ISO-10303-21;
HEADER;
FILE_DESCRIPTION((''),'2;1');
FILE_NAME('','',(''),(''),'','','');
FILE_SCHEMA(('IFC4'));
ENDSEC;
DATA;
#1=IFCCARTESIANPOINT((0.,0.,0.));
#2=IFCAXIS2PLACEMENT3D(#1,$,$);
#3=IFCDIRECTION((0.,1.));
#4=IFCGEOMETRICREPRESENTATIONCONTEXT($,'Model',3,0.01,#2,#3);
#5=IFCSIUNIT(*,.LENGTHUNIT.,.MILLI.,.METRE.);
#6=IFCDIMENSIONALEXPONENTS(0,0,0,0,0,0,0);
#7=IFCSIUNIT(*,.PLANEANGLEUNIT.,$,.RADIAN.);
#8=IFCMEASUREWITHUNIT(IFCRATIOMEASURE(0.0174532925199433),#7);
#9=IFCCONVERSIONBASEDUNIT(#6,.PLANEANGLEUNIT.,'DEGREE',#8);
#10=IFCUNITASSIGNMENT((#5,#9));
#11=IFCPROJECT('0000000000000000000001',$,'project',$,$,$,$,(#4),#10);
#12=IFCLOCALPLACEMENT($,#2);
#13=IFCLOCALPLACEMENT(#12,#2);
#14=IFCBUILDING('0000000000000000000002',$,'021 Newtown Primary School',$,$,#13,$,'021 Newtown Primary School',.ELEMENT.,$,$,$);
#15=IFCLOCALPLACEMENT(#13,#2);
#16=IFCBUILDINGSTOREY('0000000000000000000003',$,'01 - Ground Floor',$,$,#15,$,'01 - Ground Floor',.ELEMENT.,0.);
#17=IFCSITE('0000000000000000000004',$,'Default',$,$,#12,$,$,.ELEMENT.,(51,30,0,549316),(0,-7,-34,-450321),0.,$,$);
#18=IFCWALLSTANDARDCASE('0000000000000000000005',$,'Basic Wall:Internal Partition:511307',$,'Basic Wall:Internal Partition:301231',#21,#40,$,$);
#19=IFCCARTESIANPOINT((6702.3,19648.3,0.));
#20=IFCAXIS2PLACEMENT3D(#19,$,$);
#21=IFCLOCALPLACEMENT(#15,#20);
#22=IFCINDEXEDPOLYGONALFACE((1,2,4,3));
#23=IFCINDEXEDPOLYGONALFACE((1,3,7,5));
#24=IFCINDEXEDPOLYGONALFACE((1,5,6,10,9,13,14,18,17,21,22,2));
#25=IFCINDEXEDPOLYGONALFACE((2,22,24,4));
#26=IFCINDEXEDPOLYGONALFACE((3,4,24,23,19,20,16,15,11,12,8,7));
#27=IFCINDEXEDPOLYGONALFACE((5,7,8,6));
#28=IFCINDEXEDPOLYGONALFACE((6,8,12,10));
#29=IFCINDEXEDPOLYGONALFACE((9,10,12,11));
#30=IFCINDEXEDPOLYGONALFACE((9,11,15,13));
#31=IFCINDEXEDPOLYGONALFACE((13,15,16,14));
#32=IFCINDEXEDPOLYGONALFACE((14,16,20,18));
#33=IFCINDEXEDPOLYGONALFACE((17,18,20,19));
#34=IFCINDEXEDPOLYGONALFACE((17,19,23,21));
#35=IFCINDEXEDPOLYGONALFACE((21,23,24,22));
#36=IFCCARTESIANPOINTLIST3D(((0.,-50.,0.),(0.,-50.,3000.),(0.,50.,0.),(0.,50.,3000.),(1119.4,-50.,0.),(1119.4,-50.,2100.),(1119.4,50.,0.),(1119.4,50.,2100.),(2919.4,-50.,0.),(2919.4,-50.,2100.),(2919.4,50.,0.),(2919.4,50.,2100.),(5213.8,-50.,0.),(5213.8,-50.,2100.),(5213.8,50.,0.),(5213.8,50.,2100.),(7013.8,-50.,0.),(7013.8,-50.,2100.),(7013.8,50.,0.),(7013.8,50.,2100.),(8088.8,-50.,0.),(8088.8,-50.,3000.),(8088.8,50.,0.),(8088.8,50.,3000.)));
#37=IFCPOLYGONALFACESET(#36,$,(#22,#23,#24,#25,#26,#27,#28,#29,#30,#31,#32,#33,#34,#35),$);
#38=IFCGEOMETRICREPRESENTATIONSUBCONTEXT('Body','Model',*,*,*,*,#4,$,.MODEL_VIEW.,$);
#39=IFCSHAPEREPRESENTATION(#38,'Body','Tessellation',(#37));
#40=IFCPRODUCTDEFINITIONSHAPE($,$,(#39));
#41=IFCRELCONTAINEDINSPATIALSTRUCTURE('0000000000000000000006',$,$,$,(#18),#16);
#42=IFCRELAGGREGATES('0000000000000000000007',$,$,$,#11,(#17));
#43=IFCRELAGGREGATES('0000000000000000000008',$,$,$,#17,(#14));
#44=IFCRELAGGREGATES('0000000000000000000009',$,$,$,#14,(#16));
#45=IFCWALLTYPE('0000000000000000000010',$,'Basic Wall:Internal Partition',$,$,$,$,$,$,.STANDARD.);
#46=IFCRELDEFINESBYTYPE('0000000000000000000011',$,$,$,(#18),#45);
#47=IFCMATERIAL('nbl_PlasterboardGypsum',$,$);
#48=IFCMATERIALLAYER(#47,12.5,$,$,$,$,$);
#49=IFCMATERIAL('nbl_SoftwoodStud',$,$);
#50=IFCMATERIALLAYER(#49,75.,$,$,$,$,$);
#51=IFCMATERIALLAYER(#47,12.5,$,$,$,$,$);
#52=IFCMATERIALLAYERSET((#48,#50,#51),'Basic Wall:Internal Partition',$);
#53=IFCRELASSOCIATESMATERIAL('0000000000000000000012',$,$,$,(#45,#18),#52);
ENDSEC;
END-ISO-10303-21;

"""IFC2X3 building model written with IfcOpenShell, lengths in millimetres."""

from ifc_helpers import new_model, entity, si_unit, converted_unit, direction, frame, frame_2d, origin, place, context, subcontext, project, spatial, rectangle, extrude, material, layer, layer_set, layer_usage, type_object, element, save


model = new_model("IFC2X3")

# Units and contexts
model_context = context("Model", 3, precision=0.01, world=origin(), true_north=direction((0.0, 1.0)))
body_context = subcontext(model_context, "Body", "Model", "MODEL_VIEW")
ifc_project = project(units=[si_unit("LENGTHUNIT", "METRE", prefix="MILLI"), converted_unit("PLANEANGLEUNIT", "DEGREE", entity("IfcRatioMeasure", 0.0174532925199433), si_unit("PLANEANGLEUNIT", "RADIAN"), dimensions=[0, 0, 0, 0, 0, 0, 0])], contexts=[model_context])

# Site, building, storey
site_placement = place(None, origin())
site = spatial("IfcSite", under=ifc_project, at=site_placement, Name="Default", CompositionType="ELEMENT", RefLatitude=(51, 30, 0, 549316), RefLongitude=(0, -7, -34, -450321), RefElevation=0.0)
building_placement = place(site_placement, origin())
building = spatial("IfcBuilding", under=site, at=building_placement, Name="021 Newtown Primary School", LongName="021 Newtown Primary School", CompositionType="ELEMENT")
storey_placement = place(building_placement, origin())
storey = spatial("IfcBuildingStorey", under=building, at=storey_placement, Name="01 - Ground Floor", LongName="01 - Ground Floor", CompositionType="ELEMENT", Elevation=0.0)

# Shared definitions
ifc_material_1 = material(Name="nbl_PlasterboardGypsum")
ifc_layer_1 = layer(ifc_material_1, 12.5)
ifc_material_2 = material(Name="nbl_SoftwoodStud")
ifc_layer_2 = layer(ifc_material_2, 75.0)
ifc_layer_3 = layer(ifc_material_1, 12.5)
ifc_layer_set_1 = layer_set([ifc_layer_1, ifc_layer_2, ifc_layer_3], Name="Basic Wall:Internal Partition")
wall_type_1 = type_object("IfcWallType", Name="Basic Wall:Internal Partition", PredefinedType="STANDARD", material=ifc_layer_set_1)

# Wall, openings
ifc_layer_usage_1 = layer_usage(ifc_layer_set_1, "AXIS2", "NEGATIVE", 50.0)
wall_1_placement = place(storey_placement, frame((6702.3, 19648.3, 0.0)))
wall_1 = element("IfcWallStandardCase", 1, at=wall_1_placement, inside=storey, type_object=wall_type_1, material=ifc_layer_usage_1, Name="Basic Wall:Internal Partition:511307", ObjectType="Basic Wall:Internal Partition:301231", context=body_context, shape_type="SweptSolid", body=[
    extrude(rectangle(XDim=8088.8, YDim=100.0, at=frame_2d((4044.4, 0.0), x_axis=(-1.0, 0.0))), origin(), (0.0, 0.0, 1.0), 3000.0),
])
opening_1_placement = place(wall_1_placement, origin())
element("IfcOpeningElement", 2, at=opening_1_placement, cuts=wall_1, ObjectType="Opening", context=body_context, shape_type="SweptSolid", body=[
    extrude(rectangle(XDim=2100.0, YDim=1800.0, at=frame_2d((0.0, 0.0), x_axis=(1.0, 0.0))), frame((2019.4, -1474.0, 1050.0), z_axis=(0.0, 1.0, 0.0), x_axis=(0.0, 0.0, 1.0)), (0.0, 0.0, 1.0), 3048.0),
])
opening_2_placement = place(wall_1_placement, origin())
element("IfcOpeningElement", 3, at=opening_2_placement, cuts=wall_1, ObjectType="Opening", context=body_context, shape_type="SweptSolid", body=[
    extrude(rectangle(XDim=2100.0, YDim=1800.0, at=frame_2d((0.0, 0.0), x_axis=(1.0, 0.0))), frame((6113.8, -1474.0, 1050.0), z_axis=(0.0, 1.0, 0.0), x_axis=(0.0, 0.0, 1.0)), (0.0, 0.0, 1.0), 3048.0),
])

save(model, "model.ifc")
